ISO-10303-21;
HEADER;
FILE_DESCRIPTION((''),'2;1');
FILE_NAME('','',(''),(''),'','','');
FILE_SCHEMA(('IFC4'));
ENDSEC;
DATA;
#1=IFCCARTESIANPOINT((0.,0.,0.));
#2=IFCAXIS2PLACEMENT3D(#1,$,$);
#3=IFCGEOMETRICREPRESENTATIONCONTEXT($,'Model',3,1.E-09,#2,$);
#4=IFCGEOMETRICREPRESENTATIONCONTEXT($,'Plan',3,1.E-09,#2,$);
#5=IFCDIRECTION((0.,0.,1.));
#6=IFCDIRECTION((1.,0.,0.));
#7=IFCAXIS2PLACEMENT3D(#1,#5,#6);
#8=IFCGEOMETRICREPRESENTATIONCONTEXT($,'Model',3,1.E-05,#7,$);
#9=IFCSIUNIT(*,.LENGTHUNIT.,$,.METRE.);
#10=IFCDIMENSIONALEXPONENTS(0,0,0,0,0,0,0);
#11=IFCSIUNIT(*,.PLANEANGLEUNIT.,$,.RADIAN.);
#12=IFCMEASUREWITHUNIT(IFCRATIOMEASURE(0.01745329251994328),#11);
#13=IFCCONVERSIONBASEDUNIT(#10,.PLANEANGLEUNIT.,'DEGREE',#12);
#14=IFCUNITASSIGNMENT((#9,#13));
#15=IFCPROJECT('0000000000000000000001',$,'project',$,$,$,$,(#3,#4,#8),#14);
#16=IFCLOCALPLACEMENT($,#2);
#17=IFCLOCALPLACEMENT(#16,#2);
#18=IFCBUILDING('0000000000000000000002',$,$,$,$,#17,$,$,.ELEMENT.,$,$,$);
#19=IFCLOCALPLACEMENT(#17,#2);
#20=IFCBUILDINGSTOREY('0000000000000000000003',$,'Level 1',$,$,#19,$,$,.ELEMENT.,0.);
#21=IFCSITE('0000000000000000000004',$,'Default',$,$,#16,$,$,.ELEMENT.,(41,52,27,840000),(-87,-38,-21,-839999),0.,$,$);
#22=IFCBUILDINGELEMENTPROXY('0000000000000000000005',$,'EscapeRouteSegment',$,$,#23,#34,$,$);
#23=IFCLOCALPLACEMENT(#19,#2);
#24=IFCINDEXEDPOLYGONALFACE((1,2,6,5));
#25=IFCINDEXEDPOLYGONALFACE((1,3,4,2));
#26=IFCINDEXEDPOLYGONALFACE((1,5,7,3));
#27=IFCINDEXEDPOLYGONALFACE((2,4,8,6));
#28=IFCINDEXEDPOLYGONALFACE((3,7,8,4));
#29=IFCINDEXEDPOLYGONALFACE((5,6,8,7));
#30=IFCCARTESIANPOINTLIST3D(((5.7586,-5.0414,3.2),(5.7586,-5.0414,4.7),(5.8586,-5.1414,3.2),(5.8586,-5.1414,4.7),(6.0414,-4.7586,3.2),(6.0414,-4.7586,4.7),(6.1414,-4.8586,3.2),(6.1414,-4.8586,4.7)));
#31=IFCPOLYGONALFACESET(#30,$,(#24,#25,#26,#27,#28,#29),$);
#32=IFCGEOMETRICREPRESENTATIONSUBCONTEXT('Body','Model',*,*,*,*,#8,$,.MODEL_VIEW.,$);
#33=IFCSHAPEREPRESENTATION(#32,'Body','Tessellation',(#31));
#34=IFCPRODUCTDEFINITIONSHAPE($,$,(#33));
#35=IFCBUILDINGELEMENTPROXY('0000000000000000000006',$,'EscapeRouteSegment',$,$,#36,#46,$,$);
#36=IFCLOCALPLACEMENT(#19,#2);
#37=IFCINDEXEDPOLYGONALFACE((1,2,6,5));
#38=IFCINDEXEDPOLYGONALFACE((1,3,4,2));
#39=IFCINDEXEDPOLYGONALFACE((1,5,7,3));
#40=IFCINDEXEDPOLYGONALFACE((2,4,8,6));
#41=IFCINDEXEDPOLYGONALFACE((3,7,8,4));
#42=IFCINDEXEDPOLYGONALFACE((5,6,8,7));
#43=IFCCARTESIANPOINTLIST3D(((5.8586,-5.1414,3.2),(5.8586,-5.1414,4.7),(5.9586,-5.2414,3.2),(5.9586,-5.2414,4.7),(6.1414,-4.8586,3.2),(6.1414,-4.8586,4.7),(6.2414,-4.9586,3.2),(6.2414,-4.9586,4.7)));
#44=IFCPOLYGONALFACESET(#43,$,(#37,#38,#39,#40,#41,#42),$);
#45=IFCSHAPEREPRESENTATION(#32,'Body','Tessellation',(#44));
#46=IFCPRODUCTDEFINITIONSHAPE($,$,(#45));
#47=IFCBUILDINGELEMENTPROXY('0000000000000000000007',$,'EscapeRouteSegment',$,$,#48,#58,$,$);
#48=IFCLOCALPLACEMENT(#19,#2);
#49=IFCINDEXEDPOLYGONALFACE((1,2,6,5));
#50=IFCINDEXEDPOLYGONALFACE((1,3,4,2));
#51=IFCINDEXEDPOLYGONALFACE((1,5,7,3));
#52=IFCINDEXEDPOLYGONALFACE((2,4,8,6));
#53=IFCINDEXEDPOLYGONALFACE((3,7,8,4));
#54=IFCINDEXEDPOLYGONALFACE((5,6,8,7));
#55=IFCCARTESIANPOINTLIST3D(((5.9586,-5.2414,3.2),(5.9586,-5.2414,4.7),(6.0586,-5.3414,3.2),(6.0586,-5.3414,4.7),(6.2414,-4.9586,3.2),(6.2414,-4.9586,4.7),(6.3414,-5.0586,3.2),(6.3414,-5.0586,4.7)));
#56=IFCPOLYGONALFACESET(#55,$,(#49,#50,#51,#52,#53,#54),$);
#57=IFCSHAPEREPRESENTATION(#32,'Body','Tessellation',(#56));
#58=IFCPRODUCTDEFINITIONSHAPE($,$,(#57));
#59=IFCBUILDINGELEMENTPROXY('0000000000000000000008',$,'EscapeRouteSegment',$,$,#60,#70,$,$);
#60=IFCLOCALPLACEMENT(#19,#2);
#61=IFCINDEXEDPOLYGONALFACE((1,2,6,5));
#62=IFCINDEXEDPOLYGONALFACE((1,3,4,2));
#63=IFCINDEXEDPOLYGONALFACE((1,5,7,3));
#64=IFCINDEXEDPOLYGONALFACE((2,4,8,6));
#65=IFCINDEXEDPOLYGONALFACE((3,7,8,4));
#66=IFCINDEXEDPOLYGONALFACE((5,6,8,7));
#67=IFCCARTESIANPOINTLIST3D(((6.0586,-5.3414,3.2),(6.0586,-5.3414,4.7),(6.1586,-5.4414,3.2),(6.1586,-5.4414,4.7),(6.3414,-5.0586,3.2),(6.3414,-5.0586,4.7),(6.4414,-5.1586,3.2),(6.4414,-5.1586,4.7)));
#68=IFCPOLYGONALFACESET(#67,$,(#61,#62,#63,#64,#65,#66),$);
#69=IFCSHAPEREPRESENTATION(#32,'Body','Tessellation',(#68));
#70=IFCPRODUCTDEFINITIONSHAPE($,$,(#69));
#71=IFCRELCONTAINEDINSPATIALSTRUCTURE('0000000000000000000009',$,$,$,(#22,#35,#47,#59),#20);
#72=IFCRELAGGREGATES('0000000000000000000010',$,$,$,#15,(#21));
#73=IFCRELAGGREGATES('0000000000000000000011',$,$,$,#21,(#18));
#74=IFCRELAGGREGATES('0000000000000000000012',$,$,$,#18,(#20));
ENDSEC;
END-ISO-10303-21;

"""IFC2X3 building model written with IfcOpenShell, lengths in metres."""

from ifc_helpers import new_model, entity, si_unit, converted_unit, frame, origin, origin_with_axes, place, context, subcontext, project, spatial, polyline, outline, extrude, element, save


model = new_model("IFC2X3")

# Units and contexts
model_context_1 = context("Model", 3, precision=1e-09, world=origin())
plan_context = context("Plan", 3, precision=1e-09, world=origin())
model_context_2 = context("Model", 3, precision=1e-05, world=origin_with_axes())
body_context = subcontext(model_context_2, "Body", "Model", "MODEL_VIEW")
ifc_project = project(units=[si_unit("LENGTHUNIT", "METRE"), converted_unit("PLANEANGLEUNIT", "DEGREE", entity("IfcRatioMeasure", 0.01745329251994328), si_unit("PLANEANGLEUNIT", "RADIAN"), dimensions=[0, 0, 0, 0, 0, 0, 0])], contexts=[model_context_1, plan_context, model_context_2])

# Site, building, storey
site_placement = place(None, origin())
site = spatial("IfcSite", under=ifc_project, at=site_placement, Name="Default", CompositionType="ELEMENT", RefLatitude=(41, 52, 27, 840000), RefLongitude=(-87, -38, -21, -839999), RefElevation=0.0)
building_placement = place(site_placement, origin())
building = spatial("IfcBuilding", under=site, at=building_placement, CompositionType="ELEMENT")
storey_placement = place(building_placement, origin())
storey = spatial("IfcBuildingStorey", under=building, at=storey_placement, Name="Level 1", CompositionType="ELEMENT", Elevation=0.0)

# Building element proxies
for number, where, z_axis, x_axis, name in (
    (1, (5.9, -4.9, 3.2), (0.0, 0.0, 1.0), (0.707107, -0.707107, 0.0), "EscapeRouteSegment"),
    (2, (6.0, -5.0, 3.2), (0.0, 0.0, 1.0), (0.707107, -0.707107, 0.0), "EscapeRouteSegment"),
    (3, (6.1, -5.1, 3.2), (0.0, 0.0, 1.0), (0.707107, -0.707107, 0.0), "EscapeRouteSegment"),
):
    element("IfcBuildingElementProxy", number, at=place(storey_placement, frame(where, z_axis=z_axis, x_axis=x_axis)), inside=storey, Name=name, context=body_context, shape_type="SweptSolid", body=[
        extrude(outline(polyline([(0.0, -0.2), (0.0, 0.2), (0.1414, 0.2), (0.1414, -0.2), (0.0, -0.2)])), origin_with_axes(), (0.0, 0.0, 1.0), 1.5),
    ])
proxy_1_placement = place(storey_placement, frame((6.2, -5.2, 3.2), z_axis=(0.0, 0.0, 1.0), x_axis=(0.707107, -0.707107, 0.0)))
element("IfcBuildingElementProxy", 4, at=proxy_1_placement, inside=storey, Name="EscapeRouteSegment", context=body_context, shape_type="SweptSolid", body=[
    extrude(outline(polyline([(0.0, -0.2), (0.0, 0.2), (0.1414, 0.2), (0.1414, -0.2), (0.0, -0.2)])), origin_with_axes(), (0.0, 0.0, 1.0), 1.5),
])

save(model, "model.ifc")
